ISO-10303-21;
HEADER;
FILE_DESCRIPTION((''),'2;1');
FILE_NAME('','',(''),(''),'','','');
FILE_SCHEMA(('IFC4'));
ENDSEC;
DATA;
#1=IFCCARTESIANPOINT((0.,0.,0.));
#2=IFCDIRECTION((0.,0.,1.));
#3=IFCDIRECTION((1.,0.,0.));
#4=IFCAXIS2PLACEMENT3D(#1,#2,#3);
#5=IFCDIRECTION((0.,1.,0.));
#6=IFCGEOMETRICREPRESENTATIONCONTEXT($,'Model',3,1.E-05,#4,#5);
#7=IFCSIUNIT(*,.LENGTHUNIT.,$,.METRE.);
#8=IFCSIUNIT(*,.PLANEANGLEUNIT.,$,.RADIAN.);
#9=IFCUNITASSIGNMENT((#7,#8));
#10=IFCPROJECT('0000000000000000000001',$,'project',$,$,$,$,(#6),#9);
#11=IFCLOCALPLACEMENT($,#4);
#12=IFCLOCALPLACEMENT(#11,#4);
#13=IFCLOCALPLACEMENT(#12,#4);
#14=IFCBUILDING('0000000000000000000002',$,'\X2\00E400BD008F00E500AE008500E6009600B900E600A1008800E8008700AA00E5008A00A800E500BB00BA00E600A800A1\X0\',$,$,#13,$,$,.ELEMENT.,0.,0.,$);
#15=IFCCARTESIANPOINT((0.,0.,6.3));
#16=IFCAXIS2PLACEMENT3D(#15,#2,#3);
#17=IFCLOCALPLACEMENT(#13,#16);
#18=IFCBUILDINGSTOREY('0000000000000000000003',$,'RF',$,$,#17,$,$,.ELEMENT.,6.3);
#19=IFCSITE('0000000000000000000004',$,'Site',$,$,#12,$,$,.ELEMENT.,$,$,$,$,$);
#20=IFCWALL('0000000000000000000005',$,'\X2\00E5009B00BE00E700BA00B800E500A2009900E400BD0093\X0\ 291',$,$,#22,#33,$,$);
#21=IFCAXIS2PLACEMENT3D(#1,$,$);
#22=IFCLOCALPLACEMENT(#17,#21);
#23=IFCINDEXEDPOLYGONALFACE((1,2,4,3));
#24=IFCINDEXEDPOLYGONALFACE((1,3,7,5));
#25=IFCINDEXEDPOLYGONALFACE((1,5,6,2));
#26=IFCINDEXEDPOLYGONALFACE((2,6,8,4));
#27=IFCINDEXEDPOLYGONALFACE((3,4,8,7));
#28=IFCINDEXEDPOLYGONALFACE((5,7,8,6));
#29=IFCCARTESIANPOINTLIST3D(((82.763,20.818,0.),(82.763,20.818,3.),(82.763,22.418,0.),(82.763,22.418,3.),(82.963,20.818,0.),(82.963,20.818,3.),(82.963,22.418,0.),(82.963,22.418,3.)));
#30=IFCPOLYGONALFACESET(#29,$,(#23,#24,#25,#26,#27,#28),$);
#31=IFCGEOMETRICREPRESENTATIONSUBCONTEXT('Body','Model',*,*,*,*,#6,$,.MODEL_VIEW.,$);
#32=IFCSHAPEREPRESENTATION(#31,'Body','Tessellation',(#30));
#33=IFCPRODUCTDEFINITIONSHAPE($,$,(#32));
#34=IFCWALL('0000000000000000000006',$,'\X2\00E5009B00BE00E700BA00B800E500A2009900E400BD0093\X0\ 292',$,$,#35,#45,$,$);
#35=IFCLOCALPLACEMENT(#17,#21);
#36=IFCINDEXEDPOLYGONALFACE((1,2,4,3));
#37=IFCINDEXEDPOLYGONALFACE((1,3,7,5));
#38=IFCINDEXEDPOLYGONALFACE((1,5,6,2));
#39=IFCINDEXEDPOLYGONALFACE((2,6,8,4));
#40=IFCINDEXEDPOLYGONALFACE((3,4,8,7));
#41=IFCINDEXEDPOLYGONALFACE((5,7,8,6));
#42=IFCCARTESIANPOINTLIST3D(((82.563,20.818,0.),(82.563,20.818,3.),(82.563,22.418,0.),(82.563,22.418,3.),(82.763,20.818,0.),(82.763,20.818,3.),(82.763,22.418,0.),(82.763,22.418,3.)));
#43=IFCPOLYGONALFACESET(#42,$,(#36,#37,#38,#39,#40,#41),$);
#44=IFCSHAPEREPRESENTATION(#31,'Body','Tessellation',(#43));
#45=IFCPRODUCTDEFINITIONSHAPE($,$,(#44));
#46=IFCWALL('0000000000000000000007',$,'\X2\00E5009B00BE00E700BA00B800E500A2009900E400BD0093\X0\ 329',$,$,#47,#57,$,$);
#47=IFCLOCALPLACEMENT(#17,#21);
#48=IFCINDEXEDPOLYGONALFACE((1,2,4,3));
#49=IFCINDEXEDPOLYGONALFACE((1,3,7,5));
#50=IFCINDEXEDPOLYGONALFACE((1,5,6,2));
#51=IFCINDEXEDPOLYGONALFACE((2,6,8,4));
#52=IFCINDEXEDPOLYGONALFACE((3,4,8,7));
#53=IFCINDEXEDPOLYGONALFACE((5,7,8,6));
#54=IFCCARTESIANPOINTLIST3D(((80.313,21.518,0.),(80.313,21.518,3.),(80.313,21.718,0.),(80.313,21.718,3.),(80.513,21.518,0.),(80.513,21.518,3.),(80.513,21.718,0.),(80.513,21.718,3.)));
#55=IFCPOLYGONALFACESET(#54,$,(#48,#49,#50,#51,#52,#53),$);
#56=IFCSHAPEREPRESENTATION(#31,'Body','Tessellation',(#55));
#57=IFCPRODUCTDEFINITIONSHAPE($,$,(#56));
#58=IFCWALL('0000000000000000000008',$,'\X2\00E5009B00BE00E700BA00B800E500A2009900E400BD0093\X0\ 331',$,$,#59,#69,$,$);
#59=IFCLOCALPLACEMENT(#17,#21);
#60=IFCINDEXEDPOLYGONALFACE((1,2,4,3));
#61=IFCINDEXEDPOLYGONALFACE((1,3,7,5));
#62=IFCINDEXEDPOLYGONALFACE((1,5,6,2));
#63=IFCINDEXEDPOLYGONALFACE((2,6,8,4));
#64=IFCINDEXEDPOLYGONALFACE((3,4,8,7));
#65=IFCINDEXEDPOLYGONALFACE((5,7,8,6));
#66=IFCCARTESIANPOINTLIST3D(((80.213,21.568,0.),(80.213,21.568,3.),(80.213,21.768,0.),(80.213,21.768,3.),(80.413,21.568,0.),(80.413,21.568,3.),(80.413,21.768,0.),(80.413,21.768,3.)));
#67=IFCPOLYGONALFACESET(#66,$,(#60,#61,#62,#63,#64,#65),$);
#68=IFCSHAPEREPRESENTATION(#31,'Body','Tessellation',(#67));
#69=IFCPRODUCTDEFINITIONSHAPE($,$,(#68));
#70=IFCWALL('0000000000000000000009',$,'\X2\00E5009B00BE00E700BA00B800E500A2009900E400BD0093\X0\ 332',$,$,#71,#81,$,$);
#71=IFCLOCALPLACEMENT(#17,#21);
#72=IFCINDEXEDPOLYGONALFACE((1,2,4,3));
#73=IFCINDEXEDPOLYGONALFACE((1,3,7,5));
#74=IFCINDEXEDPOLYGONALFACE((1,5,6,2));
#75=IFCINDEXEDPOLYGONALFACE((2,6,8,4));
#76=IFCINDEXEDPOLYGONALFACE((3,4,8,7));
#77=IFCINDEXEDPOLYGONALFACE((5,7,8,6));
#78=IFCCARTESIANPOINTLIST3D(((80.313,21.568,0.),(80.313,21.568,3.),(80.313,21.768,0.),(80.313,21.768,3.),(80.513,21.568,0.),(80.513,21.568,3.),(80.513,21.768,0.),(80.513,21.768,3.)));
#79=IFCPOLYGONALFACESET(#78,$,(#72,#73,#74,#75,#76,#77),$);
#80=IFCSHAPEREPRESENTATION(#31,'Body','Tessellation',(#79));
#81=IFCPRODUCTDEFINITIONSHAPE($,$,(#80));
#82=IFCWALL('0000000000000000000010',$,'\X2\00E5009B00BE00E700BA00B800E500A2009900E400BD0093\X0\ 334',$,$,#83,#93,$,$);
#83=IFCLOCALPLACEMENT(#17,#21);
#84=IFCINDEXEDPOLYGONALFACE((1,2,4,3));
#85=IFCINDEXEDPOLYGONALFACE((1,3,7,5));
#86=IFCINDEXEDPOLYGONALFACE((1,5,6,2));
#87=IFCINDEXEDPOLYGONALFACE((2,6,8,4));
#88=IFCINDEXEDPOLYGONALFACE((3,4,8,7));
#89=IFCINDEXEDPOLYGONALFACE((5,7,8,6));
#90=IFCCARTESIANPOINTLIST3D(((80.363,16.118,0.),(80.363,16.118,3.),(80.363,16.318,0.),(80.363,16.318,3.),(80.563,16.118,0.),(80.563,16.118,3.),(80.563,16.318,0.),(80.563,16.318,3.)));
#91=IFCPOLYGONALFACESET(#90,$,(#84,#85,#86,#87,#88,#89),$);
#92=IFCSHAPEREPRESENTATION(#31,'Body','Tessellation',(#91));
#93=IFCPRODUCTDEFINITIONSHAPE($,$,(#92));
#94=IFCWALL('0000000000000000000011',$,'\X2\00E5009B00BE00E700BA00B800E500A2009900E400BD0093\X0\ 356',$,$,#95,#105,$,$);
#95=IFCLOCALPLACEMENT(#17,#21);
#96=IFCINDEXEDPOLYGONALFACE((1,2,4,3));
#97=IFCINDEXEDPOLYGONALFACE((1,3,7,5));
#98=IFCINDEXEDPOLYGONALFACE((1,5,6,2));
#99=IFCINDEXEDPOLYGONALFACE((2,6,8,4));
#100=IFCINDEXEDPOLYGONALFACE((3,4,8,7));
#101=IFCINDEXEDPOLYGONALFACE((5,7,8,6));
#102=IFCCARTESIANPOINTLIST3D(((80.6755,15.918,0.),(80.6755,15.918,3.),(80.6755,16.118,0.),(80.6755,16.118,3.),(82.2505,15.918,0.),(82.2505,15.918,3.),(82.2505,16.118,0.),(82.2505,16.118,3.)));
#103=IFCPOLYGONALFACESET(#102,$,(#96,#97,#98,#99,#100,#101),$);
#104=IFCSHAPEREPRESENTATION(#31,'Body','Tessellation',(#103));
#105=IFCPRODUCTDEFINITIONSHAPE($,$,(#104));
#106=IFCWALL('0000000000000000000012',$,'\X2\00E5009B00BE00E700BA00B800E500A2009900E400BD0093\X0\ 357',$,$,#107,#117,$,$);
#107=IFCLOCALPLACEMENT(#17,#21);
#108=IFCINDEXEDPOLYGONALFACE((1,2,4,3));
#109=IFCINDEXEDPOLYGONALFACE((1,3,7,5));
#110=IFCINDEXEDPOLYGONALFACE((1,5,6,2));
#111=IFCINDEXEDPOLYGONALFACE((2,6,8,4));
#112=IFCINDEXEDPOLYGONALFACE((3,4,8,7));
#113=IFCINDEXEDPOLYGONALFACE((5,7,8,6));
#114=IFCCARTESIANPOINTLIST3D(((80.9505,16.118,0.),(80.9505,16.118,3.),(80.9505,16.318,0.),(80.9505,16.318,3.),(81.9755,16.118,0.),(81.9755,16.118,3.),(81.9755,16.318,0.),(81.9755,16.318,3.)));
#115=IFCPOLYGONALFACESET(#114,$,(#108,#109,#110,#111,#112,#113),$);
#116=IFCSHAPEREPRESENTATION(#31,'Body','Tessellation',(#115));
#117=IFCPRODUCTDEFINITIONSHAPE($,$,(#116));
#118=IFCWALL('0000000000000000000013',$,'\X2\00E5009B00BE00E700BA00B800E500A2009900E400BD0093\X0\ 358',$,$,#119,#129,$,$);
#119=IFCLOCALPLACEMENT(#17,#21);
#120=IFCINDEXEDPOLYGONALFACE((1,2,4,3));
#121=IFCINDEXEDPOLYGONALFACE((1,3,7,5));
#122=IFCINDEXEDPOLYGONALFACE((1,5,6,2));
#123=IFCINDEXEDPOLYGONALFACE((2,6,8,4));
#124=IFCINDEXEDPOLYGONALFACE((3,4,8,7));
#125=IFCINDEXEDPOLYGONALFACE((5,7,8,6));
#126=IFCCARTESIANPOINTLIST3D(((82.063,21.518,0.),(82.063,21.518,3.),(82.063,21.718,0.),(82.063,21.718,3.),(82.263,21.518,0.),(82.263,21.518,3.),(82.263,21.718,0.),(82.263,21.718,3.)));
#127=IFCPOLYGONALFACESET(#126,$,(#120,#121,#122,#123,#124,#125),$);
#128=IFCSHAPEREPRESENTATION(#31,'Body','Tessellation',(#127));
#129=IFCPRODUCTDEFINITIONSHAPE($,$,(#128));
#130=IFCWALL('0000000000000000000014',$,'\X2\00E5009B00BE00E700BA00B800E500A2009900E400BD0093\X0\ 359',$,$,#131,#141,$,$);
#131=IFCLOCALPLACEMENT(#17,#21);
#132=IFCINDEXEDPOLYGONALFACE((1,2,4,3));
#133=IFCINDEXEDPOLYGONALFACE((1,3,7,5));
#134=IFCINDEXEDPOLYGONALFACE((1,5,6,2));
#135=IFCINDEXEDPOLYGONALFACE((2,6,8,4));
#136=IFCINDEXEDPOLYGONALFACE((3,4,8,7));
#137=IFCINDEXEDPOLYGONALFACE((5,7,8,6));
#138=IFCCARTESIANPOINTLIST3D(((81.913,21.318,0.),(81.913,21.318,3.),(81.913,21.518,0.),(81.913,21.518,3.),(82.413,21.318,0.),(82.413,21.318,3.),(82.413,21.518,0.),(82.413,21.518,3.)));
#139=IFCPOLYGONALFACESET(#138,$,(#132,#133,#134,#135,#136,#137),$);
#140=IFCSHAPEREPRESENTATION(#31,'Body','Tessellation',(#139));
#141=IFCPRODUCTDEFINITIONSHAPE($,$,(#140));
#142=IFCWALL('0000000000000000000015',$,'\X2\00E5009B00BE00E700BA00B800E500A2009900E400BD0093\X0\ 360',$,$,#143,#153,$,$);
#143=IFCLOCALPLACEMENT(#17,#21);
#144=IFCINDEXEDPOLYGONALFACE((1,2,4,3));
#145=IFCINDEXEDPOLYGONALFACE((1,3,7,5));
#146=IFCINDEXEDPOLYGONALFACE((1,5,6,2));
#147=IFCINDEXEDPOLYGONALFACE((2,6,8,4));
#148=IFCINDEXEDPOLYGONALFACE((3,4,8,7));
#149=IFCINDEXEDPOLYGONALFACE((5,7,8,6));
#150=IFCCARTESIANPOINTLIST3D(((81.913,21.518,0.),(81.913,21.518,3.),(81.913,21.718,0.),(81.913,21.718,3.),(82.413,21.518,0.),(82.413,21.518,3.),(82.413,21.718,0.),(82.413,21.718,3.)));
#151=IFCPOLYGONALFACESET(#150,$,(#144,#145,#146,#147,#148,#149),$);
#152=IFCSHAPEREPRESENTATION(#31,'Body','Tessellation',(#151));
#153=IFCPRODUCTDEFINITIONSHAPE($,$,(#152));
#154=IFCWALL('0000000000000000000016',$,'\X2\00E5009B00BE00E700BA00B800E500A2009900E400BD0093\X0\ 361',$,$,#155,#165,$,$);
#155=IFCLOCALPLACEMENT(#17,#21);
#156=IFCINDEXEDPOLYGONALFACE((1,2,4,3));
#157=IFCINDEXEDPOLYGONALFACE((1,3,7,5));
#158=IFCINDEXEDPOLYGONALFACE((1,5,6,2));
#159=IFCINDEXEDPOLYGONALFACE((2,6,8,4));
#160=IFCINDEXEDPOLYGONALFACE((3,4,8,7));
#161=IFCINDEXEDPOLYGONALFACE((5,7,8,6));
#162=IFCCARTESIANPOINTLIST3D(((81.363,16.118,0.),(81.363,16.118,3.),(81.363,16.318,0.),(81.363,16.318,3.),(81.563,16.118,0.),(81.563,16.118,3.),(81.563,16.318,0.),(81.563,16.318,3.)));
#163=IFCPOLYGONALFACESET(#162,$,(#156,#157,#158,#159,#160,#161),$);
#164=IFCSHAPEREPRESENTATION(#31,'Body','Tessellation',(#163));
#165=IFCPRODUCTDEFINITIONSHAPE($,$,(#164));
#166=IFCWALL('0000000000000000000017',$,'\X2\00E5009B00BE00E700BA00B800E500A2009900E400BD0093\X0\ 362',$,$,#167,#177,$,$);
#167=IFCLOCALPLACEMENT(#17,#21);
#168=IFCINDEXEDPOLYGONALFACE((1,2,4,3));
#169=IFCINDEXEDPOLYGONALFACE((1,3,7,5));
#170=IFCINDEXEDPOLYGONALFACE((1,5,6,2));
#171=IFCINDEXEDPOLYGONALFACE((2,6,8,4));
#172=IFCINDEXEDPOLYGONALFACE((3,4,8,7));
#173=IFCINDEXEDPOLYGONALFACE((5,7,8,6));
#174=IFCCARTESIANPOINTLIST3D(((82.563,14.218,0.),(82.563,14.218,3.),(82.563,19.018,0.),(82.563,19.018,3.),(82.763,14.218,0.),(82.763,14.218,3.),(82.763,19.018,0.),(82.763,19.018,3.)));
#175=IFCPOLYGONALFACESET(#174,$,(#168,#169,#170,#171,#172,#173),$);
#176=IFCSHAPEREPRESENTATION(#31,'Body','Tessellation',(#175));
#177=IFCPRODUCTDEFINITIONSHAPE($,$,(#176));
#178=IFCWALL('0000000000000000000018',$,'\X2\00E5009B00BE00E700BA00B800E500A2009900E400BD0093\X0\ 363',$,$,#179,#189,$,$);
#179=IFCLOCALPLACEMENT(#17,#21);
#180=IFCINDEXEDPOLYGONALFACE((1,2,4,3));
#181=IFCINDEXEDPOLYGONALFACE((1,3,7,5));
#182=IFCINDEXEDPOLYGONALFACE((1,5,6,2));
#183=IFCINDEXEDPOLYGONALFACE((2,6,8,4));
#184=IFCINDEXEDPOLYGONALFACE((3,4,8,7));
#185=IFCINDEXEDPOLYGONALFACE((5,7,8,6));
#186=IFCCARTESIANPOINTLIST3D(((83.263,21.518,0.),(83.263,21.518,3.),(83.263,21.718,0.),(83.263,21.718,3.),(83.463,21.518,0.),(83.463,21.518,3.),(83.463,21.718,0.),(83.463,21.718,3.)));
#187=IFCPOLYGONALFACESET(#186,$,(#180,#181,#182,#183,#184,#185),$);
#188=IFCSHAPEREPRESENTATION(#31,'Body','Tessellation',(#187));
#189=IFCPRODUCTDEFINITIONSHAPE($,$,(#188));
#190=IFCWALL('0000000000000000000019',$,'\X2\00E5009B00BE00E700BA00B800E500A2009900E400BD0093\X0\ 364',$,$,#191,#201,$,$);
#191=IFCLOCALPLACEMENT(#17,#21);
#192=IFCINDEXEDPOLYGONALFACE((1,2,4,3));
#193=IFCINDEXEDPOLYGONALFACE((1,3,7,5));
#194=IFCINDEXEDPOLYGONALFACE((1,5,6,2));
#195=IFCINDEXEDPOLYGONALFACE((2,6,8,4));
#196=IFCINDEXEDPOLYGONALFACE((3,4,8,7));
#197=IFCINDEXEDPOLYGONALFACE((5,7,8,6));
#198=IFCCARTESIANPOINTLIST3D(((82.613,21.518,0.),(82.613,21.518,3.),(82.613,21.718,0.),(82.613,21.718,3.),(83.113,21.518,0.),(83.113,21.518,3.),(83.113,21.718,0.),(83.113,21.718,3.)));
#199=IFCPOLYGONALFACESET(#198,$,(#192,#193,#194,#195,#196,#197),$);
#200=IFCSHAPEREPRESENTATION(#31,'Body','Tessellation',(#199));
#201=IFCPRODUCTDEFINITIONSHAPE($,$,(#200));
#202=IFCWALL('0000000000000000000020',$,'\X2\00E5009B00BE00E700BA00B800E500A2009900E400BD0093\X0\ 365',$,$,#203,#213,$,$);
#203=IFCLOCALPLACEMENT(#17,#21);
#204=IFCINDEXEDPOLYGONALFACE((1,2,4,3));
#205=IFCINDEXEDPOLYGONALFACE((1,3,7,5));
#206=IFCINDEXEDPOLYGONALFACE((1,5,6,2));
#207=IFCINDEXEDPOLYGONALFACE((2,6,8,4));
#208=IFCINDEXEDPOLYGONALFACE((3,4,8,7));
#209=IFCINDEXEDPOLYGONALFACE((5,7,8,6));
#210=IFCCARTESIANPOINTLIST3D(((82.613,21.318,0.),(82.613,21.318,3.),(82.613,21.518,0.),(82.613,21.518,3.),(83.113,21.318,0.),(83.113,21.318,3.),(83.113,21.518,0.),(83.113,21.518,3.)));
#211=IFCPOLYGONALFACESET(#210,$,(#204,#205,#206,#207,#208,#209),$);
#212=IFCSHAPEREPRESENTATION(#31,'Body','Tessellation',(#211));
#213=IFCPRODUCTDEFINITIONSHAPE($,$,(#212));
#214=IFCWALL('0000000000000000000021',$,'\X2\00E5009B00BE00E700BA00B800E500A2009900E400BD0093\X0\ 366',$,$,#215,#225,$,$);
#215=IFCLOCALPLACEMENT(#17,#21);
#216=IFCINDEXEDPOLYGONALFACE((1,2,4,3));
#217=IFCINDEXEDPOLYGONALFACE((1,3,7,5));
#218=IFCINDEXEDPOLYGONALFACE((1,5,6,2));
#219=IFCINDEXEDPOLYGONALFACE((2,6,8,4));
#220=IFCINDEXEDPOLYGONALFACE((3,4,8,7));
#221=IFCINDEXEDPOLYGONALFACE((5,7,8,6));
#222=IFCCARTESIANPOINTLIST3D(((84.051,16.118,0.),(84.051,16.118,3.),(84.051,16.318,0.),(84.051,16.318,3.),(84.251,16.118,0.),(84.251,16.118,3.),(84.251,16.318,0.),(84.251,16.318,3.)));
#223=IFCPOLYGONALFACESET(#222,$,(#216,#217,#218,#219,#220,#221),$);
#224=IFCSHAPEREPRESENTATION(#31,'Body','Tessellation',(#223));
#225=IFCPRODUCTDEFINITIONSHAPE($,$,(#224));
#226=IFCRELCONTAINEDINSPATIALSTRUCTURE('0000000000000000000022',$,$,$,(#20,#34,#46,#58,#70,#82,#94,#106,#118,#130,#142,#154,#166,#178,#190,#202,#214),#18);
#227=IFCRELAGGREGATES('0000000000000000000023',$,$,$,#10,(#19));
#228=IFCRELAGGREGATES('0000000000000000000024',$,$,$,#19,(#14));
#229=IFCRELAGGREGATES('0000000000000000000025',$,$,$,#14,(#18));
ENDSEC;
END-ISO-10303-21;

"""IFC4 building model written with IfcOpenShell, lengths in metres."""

from ifc_helpers import new_model, si_unit, direction, frame, frame_2d, origin_with_axes, place, context, subcontext, project, spatial, rectangle, extrude, element, save


model = new_model("IFC4")

# Units and contexts
model_context = context("Model", 3, precision=1e-05, world=origin_with_axes(), true_north=direction((0.0, 1.0, 0.0)))
body_context = subcontext(model_context, "Body", "Model", "MODEL_VIEW")
ifc_project = project(units=[si_unit("LENGTHUNIT", "METRE"), si_unit("PLANEANGLEUNIT", "RADIAN")], contexts=[model_context])

# Site, building, storey
placement = place(None, origin_with_axes())
site_placement = place(placement, origin_with_axes())
site = spatial("IfcSite", under=ifc_project, at=site_placement, Name="Site", CompositionType="ELEMENT")
building_placement = place(site_placement, origin_with_axes())
building = spatial("IfcBuilding", under=site, at=building_placement, Name="ä½\u008få®\u0085æ\u0096¹æ¡\u0088è\u0087ªå\u008a¨å»ºæ¨¡", CompositionType="ELEMENT", ElevationOfRefHeight=0.0, ElevationOfTerrain=0.0)
storey_placement = place(building_placement, frame((0.0, 0.0, 6.3), z_axis=(0.0, 0.0, 1.0), x_axis=(1.0, 0.0, 0.0)))
storey = spatial("IfcBuildingStorey", under=building, at=storey_placement, Name="RF", CompositionType="ELEMENT", Elevation=6.3)

# Walls
for number, where, z_axis, x_axis, name in (
    (1, (82.863, 21.618, 0.0), (0.0, 0.0, 1.0), (0.0, 1.0, 0.0), "å\u009b¾çº¸å¢\u0099ä½\u0093 291"),
    (2, (82.663, 21.618, 0.0), (0.0, 0.0, 1.0), (0.0, 1.0, 0.0), "å\u009b¾çº¸å¢\u0099ä½\u0093 292"),
):
    element("IfcWall", number, at=place(storey_placement, frame(where, z_axis=z_axis, x_axis=x_axis)), inside=storey, Name=name, context=body_context, shape_type="SweptSolid", body=[
        extrude(rectangle(XDim=1.6, YDim=0.2, at=frame_2d((0.0, 0.0), x_axis=(1.0, 0.0, 0.0))), frame((0.0, 0.0, 0.0), z_axis=(0.0, 0.0, 1.0)), (0.0, 0.0, 1.0), 3.0),
    ])
for number, where, z_axis, x_axis, name in (
    (3, (80.413, 21.618, 0.0), (0.0, 0.0, 1.0), (0.0, -1.0, 0.0), "å\u009b¾çº¸å¢\u0099ä½\u0093 329"),
    (4, (80.313, 21.668, 0.0), (0.0, 0.0, 1.0), (1.0, 0.0, 0.0), "å\u009b¾çº¸å¢\u0099ä½\u0093 331"),
    (5, (80.413, 21.668, 0.0), (0.0, 0.0, 1.0), (0.0, -1.0, 0.0), "å\u009b¾çº¸å¢\u0099ä½\u0093 332"),
    (6, (80.463, 16.218, 0.0), (0.0, 0.0, 1.0), (0.0, -1.0, 0.0), "å\u009b¾çº¸å¢\u0099ä½\u0093 334"),
):
    element("IfcWall", number, at=place(storey_placement, frame(where, z_axis=z_axis, x_axis=x_axis)), inside=storey, Name=name, context=body_context, shape_type="SweptSolid", body=[
        extrude(rectangle(XDim=0.2, YDim=0.2, at=frame_2d((0.0, 0.0), x_axis=(1.0, 0.0, 0.0))), frame((0.0, 0.0, 0.0), z_axis=(0.0, 0.0, 1.0)), (0.0, 0.0, 1.0), 3.0),
    ])
wall_1_placement = place(storey_placement, frame((81.463, 16.018, 0.0), z_axis=(0.0, 0.0, 1.0), x_axis=(1.0, 0.0, 0.0)))
element("IfcWall", 7, at=wall_1_placement, inside=storey, Name="å\u009b¾çº¸å¢\u0099ä½\u0093 356", context=body_context, shape_type="SweptSolid", body=[
    extrude(rectangle(XDim=1.575, YDim=0.2, at=frame_2d((0.0, 0.0), x_axis=(1.0, 0.0, 0.0))), frame((0.0, 0.0, 0.0), z_axis=(0.0, 0.0, 1.0)), (0.0, 0.0, 1.0), 3.0),
])
wall_2_placement = place(storey_placement, frame((81.463, 16.218, 0.0), z_axis=(0.0, 0.0, 1.0), x_axis=(1.0, 0.0, 0.0)))
element("IfcWall", 8, at=wall_2_placement, inside=storey, Name="å\u009b¾çº¸å¢\u0099ä½\u0093 357", context=body_context, shape_type="SweptSolid", body=[
    extrude(rectangle(XDim=1.025, YDim=0.2, at=frame_2d((0.0, 0.0), x_axis=(1.0, 0.0, 0.0))), frame((0.0, 0.0, 0.0), z_axis=(0.0, 0.0, 1.0)), (0.0, 0.0, 1.0), 3.0),
])
wall_3_placement = place(storey_placement, frame((82.163, 21.618, 0.0), z_axis=(0.0, 0.0, 1.0), x_axis=(0.0, -1.0, 0.0)))
element("IfcWall", 9, at=wall_3_placement, inside=storey, Name="å\u009b¾çº¸å¢\u0099ä½\u0093 358", context=body_context, shape_type="SweptSolid", body=[
    extrude(rectangle(XDim=0.2, YDim=0.2, at=frame_2d((0.0, 0.0), x_axis=(1.0, 0.0, 0.0))), frame((0.0, 0.0, 0.0), z_axis=(0.0, 0.0, 1.0)), (0.0, 0.0, 1.0), 3.0),
])
for number, where, z_axis, x_axis, name in (
    (10, (82.163, 21.418, 0.0), (0.0, 0.0, 1.0), (1.0, 0.0, 0.0), "å\u009b¾çº¸å¢\u0099ä½\u0093 359"),
    (11, (82.163, 21.618, 0.0), (0.0, 0.0, 1.0), (1.0, 0.0, 0.0), "å\u009b¾çº¸å¢\u0099ä½\u0093 360"),
):
    element("IfcWall", number, at=place(storey_placement, frame(where, z_axis=z_axis, x_axis=x_axis)), inside=storey, Name=name, context=body_context, shape_type="SweptSolid", body=[
        extrude(rectangle(XDim=0.5, YDim=0.2, at=frame_2d((0.0, 0.0), x_axis=(1.0, 0.0, 0.0))), frame((0.0, 0.0, 0.0), z_axis=(0.0, 0.0, 1.0)), (0.0, 0.0, 1.0), 3.0),
    ])
wall_4_placement = place(storey_placement, frame((81.463, 16.218, 0.0), z_axis=(0.0, 0.0, 1.0), x_axis=(0.0, -1.0, 0.0)))
element("IfcWall", 12, at=wall_4_placement, inside=storey, Name="å\u009b¾çº¸å¢\u0099ä½\u0093 361", context=body_context, shape_type="SweptSolid", body=[
    extrude(rectangle(XDim=0.2, YDim=0.2, at=frame_2d((0.0, 0.0), x_axis=(1.0, 0.0, 0.0))), frame((0.0, 0.0, 0.0), z_axis=(0.0, 0.0, 1.0)), (0.0, 0.0, 1.0), 3.0),
])
wall_5_placement = place(storey_placement, frame((82.663, 16.618, 0.0), z_axis=(0.0, 0.0, 1.0), x_axis=(0.0, 1.0, 0.0)))
element("IfcWall", 13, at=wall_5_placement, inside=storey, Name="å\u009b¾çº¸å¢\u0099ä½\u0093 362", context=body_context, shape_type="SweptSolid", body=[
    extrude(rectangle(XDim=4.8, YDim=0.2, at=frame_2d((0.0, 0.0), x_axis=(1.0, 0.0, 0.0))), frame((0.0, 0.0, 0.0), z_axis=(0.0, 0.0, 1.0)), (0.0, 0.0, 1.0), 3.0),
])
wall_6_placement = place(storey_placement, frame((83.363, 21.618, 0.0), z_axis=(0.0, 0.0, 1.0), x_axis=(0.0, -1.0, 0.0)))
element("IfcWall", 14, at=wall_6_placement, inside=storey, Name="å\u009b¾çº¸å¢\u0099ä½\u0093 363", context=body_context, shape_type="SweptSolid", body=[
    extrude(rectangle(XDim=0.2, YDim=0.2, at=frame_2d((0.0, 0.0), x_axis=(1.0, 0.0, 0.0))), frame((0.0, 0.0, 0.0), z_axis=(0.0, 0.0, 1.0)), (0.0, 0.0, 1.0), 3.0),
])
for number, where, z_axis, x_axis, name in (
    (15, (82.863, 21.618, 0.0), (0.0, 0.0, 1.0), (1.0, 0.0, 0.0), "å\u009b¾çº¸å¢\u0099ä½\u0093 364"),
    (16, (82.863, 21.418, 0.0), (0.0, 0.0, 1.0), (1.0, 0.0, 0.0), "å\u009b¾çº¸å¢\u0099ä½\u0093 365"),
):
    element("IfcWall", number, at=place(storey_placement, frame(where, z_axis=z_axis, x_axis=x_axis)), inside=storey, Name=name, context=body_context, shape_type="SweptSolid", body=[
        extrude(rectangle(XDim=0.5, YDim=0.2, at=frame_2d((0.0, 0.0), x_axis=(1.0, 0.0, 0.0))), frame((0.0, 0.0, 0.0), z_axis=(0.0, 0.0, 1.0)), (0.0, 0.0, 1.0), 3.0),
    ])
wall_7_placement = place(storey_placement, frame((84.151, 16.218, 0.0), z_axis=(0.0, 0.0, 1.0), x_axis=(0.0, -1.0, 0.0)))
element("IfcWall", 17, at=wall_7_placement, inside=storey, Name="å\u009b¾çº¸å¢\u0099ä½\u0093 366", context=body_context, shape_type="SweptSolid", body=[
    extrude(rectangle(XDim=0.2, YDim=0.2, at=frame_2d((0.0, 0.0), x_axis=(1.0, 0.0, 0.0))), frame((0.0, 0.0, 0.0), z_axis=(0.0, 0.0, 1.0)), (0.0, 0.0, 1.0), 3.0),
])

save(model, "model.ifc")
